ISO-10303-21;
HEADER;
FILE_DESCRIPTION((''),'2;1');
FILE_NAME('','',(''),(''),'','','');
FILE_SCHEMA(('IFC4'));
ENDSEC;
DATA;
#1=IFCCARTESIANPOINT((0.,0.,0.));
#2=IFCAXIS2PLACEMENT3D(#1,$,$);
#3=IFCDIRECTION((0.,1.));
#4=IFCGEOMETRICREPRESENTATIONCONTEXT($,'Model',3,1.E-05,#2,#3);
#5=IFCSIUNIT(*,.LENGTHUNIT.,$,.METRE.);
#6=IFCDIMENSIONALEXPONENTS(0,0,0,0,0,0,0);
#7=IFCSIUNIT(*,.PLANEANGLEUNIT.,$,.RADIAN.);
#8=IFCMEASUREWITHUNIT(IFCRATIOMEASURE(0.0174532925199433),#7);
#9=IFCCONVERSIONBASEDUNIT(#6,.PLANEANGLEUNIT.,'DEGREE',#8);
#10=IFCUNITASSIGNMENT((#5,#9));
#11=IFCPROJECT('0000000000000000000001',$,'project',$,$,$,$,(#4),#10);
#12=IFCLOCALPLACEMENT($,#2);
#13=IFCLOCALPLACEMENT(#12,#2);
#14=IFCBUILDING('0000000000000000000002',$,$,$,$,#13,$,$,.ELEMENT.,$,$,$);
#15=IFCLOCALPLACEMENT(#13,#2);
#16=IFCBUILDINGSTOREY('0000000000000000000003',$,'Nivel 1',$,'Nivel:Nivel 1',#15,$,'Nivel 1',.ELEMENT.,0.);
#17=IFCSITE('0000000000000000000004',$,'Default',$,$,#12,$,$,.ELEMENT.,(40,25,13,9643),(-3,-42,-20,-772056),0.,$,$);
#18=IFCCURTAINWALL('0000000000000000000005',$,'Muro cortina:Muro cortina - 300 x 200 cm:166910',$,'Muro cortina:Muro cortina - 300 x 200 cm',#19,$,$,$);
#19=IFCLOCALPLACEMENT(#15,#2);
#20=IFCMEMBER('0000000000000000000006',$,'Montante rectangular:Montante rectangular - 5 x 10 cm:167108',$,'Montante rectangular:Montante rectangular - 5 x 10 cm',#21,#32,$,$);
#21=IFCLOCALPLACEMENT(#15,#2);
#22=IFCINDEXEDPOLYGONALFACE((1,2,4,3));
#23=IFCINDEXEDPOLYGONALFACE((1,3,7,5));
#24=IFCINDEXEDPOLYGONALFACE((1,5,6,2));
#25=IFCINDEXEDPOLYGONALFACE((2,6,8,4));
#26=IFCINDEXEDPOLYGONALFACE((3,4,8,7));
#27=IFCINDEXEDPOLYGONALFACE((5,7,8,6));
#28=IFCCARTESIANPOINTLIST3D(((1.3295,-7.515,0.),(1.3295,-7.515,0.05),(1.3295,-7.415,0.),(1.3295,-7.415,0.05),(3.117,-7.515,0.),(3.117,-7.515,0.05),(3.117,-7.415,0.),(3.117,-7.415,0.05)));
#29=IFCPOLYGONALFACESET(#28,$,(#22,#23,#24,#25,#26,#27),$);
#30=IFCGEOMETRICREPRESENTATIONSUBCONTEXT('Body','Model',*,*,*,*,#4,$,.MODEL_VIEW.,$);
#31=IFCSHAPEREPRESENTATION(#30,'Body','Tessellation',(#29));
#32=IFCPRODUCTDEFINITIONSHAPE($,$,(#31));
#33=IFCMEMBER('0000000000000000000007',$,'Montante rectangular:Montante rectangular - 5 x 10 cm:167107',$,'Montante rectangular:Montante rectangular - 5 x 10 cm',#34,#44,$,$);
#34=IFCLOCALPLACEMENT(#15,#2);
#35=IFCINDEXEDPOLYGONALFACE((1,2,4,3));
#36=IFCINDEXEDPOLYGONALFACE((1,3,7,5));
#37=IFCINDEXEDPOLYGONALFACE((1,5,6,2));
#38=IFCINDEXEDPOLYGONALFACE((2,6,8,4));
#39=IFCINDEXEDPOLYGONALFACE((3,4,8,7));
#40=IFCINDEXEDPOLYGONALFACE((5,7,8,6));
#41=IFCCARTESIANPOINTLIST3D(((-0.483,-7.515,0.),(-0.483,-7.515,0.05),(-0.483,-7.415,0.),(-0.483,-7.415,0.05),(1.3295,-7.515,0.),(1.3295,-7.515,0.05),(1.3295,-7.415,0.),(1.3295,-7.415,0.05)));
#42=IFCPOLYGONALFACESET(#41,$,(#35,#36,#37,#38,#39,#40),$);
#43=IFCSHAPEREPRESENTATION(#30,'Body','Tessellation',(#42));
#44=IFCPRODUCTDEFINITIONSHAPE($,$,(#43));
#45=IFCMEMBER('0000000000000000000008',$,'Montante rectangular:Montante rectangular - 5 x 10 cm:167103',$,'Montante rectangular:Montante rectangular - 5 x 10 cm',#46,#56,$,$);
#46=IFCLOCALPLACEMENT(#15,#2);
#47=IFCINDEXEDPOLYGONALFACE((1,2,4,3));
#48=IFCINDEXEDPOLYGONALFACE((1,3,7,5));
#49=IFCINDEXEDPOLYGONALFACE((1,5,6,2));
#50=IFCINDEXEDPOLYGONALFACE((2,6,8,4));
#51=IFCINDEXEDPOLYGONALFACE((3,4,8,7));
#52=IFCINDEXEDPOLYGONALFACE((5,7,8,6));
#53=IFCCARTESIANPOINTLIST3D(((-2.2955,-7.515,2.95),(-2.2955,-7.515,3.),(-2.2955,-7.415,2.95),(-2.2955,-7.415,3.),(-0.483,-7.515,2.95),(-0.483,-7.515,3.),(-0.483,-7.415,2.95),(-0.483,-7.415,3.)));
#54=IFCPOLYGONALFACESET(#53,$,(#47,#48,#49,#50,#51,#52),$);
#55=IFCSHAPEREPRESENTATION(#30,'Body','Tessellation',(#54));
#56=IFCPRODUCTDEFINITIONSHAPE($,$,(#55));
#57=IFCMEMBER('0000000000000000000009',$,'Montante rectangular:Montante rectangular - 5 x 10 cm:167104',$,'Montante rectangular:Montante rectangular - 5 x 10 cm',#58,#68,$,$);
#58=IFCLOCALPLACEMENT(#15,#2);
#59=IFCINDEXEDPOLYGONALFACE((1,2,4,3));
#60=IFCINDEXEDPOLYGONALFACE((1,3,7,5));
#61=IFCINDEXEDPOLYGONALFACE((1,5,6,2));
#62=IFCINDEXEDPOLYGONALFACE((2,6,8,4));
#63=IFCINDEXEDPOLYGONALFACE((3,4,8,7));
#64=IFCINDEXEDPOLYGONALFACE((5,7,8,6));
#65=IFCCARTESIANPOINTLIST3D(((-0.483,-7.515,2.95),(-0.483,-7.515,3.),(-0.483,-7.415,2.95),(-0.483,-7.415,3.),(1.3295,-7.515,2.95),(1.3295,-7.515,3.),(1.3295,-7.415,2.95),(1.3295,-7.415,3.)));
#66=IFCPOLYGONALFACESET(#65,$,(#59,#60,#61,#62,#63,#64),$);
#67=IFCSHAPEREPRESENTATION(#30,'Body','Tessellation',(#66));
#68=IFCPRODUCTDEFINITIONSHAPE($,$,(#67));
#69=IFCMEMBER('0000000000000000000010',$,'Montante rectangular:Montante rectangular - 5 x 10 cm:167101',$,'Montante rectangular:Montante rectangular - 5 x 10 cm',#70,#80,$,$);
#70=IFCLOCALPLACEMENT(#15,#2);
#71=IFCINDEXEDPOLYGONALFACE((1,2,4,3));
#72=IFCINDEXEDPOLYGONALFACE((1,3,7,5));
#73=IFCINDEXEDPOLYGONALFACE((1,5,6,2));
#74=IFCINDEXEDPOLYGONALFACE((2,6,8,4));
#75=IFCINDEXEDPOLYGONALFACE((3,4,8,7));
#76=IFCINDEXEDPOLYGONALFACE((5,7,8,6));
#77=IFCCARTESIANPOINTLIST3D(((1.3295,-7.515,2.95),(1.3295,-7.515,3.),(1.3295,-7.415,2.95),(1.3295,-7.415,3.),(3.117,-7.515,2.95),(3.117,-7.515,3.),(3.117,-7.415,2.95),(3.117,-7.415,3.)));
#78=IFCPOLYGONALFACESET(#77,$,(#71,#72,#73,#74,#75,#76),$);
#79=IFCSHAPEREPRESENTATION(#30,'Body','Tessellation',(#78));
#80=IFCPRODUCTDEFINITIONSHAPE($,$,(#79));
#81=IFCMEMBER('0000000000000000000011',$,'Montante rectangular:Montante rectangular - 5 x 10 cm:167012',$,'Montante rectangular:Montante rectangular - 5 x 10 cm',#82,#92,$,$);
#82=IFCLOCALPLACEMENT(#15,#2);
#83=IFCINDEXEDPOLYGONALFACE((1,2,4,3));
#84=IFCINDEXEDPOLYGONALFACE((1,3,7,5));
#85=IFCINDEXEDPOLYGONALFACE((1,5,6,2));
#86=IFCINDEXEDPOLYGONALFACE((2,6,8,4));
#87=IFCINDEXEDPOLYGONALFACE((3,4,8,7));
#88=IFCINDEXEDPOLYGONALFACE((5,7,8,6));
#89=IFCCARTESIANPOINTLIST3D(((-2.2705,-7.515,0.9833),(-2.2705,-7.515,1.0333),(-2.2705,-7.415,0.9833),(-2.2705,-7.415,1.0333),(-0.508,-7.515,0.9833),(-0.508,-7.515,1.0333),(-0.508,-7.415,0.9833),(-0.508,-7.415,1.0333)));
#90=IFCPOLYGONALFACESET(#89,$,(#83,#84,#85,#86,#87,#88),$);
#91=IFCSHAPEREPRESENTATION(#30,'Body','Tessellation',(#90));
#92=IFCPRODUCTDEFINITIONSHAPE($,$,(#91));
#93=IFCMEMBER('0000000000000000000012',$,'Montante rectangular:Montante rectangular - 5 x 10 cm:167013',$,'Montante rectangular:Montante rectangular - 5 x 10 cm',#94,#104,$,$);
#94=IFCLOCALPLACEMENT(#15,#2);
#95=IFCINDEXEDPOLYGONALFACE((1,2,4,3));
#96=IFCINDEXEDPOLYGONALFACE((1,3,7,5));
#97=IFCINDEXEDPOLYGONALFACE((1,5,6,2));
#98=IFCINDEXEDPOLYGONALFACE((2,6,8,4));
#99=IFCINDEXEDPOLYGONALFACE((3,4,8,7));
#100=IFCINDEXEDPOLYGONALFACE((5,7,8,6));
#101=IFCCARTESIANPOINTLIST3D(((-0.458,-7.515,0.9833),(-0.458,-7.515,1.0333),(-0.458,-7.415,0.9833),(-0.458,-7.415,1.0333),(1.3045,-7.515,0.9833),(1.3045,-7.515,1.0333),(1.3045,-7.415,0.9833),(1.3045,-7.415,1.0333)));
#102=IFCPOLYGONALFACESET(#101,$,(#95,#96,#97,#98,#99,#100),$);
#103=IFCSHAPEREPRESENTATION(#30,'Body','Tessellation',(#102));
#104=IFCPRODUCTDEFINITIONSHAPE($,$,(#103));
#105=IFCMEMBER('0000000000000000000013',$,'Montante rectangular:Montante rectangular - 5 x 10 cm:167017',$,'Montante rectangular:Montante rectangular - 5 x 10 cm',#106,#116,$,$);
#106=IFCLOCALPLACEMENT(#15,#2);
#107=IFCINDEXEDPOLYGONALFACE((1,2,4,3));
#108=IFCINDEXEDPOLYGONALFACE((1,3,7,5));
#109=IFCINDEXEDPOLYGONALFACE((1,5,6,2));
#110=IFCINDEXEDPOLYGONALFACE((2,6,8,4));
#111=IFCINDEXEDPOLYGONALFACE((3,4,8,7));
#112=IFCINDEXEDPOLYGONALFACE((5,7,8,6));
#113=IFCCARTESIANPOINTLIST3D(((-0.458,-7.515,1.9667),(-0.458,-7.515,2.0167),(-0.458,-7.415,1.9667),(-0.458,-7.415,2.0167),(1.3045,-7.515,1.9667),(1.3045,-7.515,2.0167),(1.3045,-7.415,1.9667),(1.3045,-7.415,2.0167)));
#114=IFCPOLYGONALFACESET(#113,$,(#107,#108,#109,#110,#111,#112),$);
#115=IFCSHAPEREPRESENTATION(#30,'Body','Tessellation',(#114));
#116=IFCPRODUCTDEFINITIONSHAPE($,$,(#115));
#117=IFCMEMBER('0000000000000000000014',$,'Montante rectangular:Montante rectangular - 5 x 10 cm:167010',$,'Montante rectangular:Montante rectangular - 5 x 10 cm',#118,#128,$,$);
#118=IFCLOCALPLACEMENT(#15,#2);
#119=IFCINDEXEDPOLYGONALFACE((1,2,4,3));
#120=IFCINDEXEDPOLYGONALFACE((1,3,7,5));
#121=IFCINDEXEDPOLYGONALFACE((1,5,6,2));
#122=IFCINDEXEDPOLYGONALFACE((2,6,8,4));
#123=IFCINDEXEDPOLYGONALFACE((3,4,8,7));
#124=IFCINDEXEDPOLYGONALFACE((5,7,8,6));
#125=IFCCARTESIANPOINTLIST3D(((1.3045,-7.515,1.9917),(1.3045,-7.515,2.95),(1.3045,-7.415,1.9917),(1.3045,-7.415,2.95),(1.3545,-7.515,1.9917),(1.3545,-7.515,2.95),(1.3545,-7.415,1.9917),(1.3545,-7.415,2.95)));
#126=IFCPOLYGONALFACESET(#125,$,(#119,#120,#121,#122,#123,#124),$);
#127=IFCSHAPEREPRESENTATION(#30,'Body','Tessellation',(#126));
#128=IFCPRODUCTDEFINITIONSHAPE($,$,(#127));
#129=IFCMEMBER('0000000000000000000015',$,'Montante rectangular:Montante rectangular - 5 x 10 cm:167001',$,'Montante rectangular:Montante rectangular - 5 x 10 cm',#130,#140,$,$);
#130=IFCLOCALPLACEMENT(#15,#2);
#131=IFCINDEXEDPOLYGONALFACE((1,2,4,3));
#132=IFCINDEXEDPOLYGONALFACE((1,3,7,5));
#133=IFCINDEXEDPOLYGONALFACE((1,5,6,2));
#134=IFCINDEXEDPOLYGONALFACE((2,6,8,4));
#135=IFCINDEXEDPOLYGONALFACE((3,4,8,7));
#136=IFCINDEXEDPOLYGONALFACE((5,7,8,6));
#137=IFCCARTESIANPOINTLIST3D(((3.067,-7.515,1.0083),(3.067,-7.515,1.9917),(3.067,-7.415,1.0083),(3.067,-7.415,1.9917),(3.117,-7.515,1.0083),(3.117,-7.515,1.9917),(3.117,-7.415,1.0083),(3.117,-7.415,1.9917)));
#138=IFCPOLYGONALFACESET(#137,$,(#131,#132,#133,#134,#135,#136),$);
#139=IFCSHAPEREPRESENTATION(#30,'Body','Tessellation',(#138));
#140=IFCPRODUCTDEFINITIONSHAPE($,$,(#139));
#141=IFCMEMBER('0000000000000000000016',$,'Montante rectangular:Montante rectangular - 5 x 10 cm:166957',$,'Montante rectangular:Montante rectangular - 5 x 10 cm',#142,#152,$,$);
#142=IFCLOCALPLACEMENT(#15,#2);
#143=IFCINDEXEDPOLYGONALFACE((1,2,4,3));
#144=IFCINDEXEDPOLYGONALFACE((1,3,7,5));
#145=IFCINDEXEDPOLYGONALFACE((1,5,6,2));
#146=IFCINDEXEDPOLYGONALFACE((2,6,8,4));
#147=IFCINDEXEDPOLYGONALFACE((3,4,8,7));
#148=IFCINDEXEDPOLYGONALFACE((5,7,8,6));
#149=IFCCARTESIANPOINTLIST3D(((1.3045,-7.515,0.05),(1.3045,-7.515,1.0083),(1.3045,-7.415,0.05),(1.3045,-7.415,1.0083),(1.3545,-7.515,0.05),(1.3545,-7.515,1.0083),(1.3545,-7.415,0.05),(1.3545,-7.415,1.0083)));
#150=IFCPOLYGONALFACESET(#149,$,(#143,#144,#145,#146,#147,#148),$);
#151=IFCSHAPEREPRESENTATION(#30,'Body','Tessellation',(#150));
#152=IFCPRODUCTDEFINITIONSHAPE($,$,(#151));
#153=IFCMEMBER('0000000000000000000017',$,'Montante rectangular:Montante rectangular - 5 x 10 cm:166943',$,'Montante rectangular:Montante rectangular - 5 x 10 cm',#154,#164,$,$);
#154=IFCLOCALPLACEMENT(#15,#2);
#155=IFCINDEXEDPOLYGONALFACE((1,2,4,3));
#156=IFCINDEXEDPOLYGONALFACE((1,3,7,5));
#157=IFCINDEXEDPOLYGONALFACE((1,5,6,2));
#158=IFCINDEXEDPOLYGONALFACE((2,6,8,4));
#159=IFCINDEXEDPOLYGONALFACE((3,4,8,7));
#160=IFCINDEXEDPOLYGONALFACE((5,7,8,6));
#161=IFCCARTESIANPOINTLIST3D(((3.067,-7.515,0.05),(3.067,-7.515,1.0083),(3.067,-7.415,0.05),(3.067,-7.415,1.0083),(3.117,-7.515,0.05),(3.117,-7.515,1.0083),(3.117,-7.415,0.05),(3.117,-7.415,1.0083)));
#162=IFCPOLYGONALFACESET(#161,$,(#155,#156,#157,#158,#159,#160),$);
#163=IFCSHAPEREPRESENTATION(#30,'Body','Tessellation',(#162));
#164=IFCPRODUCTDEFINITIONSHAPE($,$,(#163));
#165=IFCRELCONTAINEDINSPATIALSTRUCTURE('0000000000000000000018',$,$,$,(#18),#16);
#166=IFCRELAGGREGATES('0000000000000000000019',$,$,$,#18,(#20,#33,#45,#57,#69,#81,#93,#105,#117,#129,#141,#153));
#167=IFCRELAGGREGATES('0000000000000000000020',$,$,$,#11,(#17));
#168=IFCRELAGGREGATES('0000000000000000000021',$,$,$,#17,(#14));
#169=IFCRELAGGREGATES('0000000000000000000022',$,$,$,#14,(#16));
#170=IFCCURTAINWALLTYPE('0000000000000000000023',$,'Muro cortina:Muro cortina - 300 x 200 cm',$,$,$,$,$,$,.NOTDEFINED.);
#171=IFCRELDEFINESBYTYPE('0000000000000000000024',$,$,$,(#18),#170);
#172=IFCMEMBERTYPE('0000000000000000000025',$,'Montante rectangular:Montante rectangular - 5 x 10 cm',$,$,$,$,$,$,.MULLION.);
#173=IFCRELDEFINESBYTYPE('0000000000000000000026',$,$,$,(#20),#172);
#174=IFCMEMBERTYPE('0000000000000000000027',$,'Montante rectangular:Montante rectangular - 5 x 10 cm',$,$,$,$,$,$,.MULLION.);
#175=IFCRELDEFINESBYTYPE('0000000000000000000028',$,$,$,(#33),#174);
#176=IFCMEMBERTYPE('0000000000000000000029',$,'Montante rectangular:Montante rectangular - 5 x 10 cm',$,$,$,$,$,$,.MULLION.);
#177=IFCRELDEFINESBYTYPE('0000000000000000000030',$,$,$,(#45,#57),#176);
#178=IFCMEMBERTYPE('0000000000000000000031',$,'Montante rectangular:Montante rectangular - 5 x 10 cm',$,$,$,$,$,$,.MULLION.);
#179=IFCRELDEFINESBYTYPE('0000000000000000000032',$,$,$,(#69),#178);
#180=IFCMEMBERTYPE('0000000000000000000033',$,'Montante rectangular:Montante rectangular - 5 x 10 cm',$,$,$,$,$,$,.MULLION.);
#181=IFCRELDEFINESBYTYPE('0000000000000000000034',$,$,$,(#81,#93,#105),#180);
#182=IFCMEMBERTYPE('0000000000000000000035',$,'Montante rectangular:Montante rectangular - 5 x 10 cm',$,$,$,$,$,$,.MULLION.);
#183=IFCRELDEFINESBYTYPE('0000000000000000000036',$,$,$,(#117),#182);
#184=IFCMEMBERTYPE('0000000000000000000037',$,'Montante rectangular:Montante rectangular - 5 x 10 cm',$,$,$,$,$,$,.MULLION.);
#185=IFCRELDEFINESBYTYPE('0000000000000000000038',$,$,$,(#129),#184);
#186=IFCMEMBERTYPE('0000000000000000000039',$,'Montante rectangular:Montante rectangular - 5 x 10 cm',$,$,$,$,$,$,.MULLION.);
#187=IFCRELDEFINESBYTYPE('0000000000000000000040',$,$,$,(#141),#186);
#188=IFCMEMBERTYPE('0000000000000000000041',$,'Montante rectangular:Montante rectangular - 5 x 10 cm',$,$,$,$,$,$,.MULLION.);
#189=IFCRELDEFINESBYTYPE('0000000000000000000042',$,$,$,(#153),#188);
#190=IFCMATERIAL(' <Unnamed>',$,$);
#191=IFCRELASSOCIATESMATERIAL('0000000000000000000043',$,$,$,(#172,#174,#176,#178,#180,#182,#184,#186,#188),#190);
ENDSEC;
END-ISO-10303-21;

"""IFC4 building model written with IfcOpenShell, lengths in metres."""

from ifc_helpers import new_model, entity, si_unit, converted_unit, direction, frame, origin, origin_2d_with_axis, place, context, subcontext, project, spatial, rectangle, extrude, source, transform, mapped, material, type_object, type_shapes, element, aggregate, save


model = new_model("IFC4")

# Units and contexts
model_context = context("Model", 3, precision=1e-05, world=origin(), true_north=direction((0.0, 1.0)))
body_context = subcontext(model_context, "Body", "Model", "MODEL_VIEW")
ifc_project = project(units=[si_unit("LENGTHUNIT", "METRE"), converted_unit("PLANEANGLEUNIT", "DEGREE", entity("IfcRatioMeasure", 0.0174532925199433), si_unit("PLANEANGLEUNIT", "RADIAN"), dimensions=[0, 0, 0, 0, 0, 0, 0])], contexts=[model_context])

# Site, building, storey
site_placement = place(None, origin())
site = spatial("IfcSite", under=ifc_project, at=site_placement, Name="Default", CompositionType="ELEMENT", RefLatitude=(40, 25, 13, 9643), RefLongitude=(-3, -42, -20, -772056), RefElevation=0.0)
building_placement = place(site_placement, origin())
building = spatial("IfcBuilding", under=site, at=building_placement, CompositionType="ELEMENT")
storey_placement = place(building_placement, origin())
storey = spatial("IfcBuildingStorey", under=building, at=storey_placement, Name="Nivel 1", ObjectType="Nivel:Nivel 1", LongName="Nivel 1", CompositionType="ELEMENT", Elevation=0.0)

# Curtain wall, members
curtain_wall_type = type_object("IfcCurtainWallType", Name="Muro cortina:Muro cortina - 300 x 200 cm", PredefinedType="NOTDEFINED")
curtain_wall_placement = place(storey_placement, origin())
curtain_wall = element("IfcCurtainWall", 1, at=curtain_wall_placement, inside=storey, type_object=curtain_wall_type, Name="Muro cortina:Muro cortina - 300 x 200 cm:166910", ObjectType="Muro cortina:Muro cortina - 300 x 200 cm")
ifc_material_1 = material(Name=" <Unnamed>")
member_type_1 = type_object("IfcMemberType", Name="Montante rectangular:Montante rectangular - 5 x 10 cm", PredefinedType="MULLION", material=ifc_material_1)
shared_shape_1 = source(origin(), body_context, "Body", "SweptSolid", [
    extrude(rectangle(XDim=0.1, YDim=0.05, at=origin_2d_with_axis()), frame((-0.025, 0.0, -1.7875), z_axis=(0.0, 0.0, 1.0), x_axis=(0.0, -1.0, 0.0)), (0.0, 0.0, 1.0), 1.7875),
])
type_shapes(member_type_1, [shared_shape_1])
member_1_placement = place(storey_placement, frame((1.3295, -7.465, 0.0), z_axis=(-1.0, 0.0, 0.0), x_axis=(0.0, 0.0, -1.0)))
member_1 = element("IfcMember", 2, at=member_1_placement, type_object=member_type_1, Name="Montante rectangular:Montante rectangular - 5 x 10 cm:167108", ObjectType="Montante rectangular:Montante rectangular - 5 x 10 cm", context=body_context, shape_type="MappedRepresentation", body=[
    mapped(shared_shape_1, transform((0.0, 0.0, 0.0), scale=1.0)),
])
member_type_2 = type_object("IfcMemberType", Name="Montante rectangular:Montante rectangular - 5 x 10 cm", PredefinedType="MULLION", material=ifc_material_1)
shared_shape_2 = source(origin(), body_context, "Body", "SweptSolid", [
    extrude(rectangle(XDim=0.1, YDim=0.05, at=origin_2d_with_axis()), frame((-0.025, 0.0, -1.8125), z_axis=(0.0, 0.0, 1.0), x_axis=(0.0, -1.0, 0.0)), (0.0, 0.0, 1.0), 1.8125),
])
type_shapes(member_type_2, [shared_shape_2])
member_2_placement = place(storey_placement, frame((-0.483, -7.465, 0.0), z_axis=(-1.0, 0.0, 0.0), x_axis=(0.0, 0.0, -1.0)))
member_2 = element("IfcMember", 3, at=member_2_placement, type_object=member_type_2, Name="Montante rectangular:Montante rectangular - 5 x 10 cm:167107", ObjectType="Montante rectangular:Montante rectangular - 5 x 10 cm", context=body_context, shape_type="MappedRepresentation", body=[
    mapped(shared_shape_2, transform((0.0, 0.0, 0.0), scale=1.0)),
])
member_type_3 = type_object("IfcMemberType", Name="Montante rectangular:Montante rectangular - 5 x 10 cm", PredefinedType="MULLION", material=ifc_material_1)
shared_shape_3 = source(origin(), body_context, "Body", "SweptSolid", [
    extrude(rectangle(XDim=0.1, YDim=0.05, at=origin_2d_with_axis()), frame((-0.025, 0.0, -1.8125), z_axis=(0.0, 0.0, 1.0), x_axis=(0.0, -1.0, 0.0)), (0.0, 0.0, 1.0), 1.8125),
])
type_shapes(member_type_3, [shared_shape_3])
member_3_placement = place(storey_placement, frame((-0.483, -7.465, 3.0), z_axis=(1.0, 0.0, 0.0), x_axis=(0.0, 0.0, 1.0)))
member_3 = element("IfcMember", 4, at=member_3_placement, type_object=member_type_3, Name="Montante rectangular:Montante rectangular - 5 x 10 cm:167103", ObjectType="Montante rectangular:Montante rectangular - 5 x 10 cm", context=body_context, shape_type="MappedRepresentation", body=[
    mapped(shared_shape_3, transform((0.0, 0.0, 0.0), scale=1.0)),
])
member_4_placement = place(storey_placement, frame((1.3295, -7.465, 3.0), z_axis=(1.0, 0.0, 0.0), x_axis=(0.0, 0.0, 1.0)))
member_4 = element("IfcMember", 5, at=member_4_placement, type_object=member_type_3, Name="Montante rectangular:Montante rectangular - 5 x 10 cm:167104", ObjectType="Montante rectangular:Montante rectangular - 5 x 10 cm", context=body_context, shape_type="MappedRepresentation", body=[
    mapped(shared_shape_3, transform((0.0, 0.0, 0.0), scale=1.0)),
])
member_type_4 = type_object("IfcMemberType", Name="Montante rectangular:Montante rectangular - 5 x 10 cm", PredefinedType="MULLION", material=ifc_material_1)
shared_shape_4 = source(origin(), body_context, "Body", "SweptSolid", [
    extrude(rectangle(XDim=0.1, YDim=0.05, at=origin_2d_with_axis()), frame((-0.025, 0.0, -1.7875), z_axis=(0.0, 0.0, 1.0), x_axis=(0.0, -1.0, 0.0)), (0.0, 0.0, 1.0), 1.7875),
])
type_shapes(member_type_4, [shared_shape_4])
member_5_placement = place(storey_placement, frame((3.117, -7.465, 3.0), z_axis=(1.0, 0.0, 0.0), x_axis=(0.0, 0.0, 1.0)))
member_5 = element("IfcMember", 6, at=member_5_placement, type_object=member_type_4, Name="Montante rectangular:Montante rectangular - 5 x 10 cm:167101", ObjectType="Montante rectangular:Montante rectangular - 5 x 10 cm", context=body_context, shape_type="MappedRepresentation", body=[
    mapped(shared_shape_4, transform((0.0, 0.0, 0.0), scale=1.0)),
])
member_type_5 = type_object("IfcMemberType", Name="Montante rectangular:Montante rectangular - 5 x 10 cm", PredefinedType="MULLION", material=ifc_material_1)
shared_shape_5 = source(origin(), body_context, "Body", "SweptSolid", [
    extrude(rectangle(XDim=0.1, YDim=0.05, at=origin_2d_with_axis()), frame((0.0, 0.0, -1.7625), z_axis=(0.0, 0.0, 1.0), x_axis=(0.0, -1.0, 0.0)), (0.0, 0.0, 1.0), 1.7625),
])
type_shapes(member_type_5, [shared_shape_5])
member_6_placement = place(storey_placement, frame((-0.508, -7.465, 1.0083), z_axis=(1.0, 0.0, 0.0), x_axis=(0.0, 0.0, 1.0)))
member_6 = element("IfcMember", 7, at=member_6_placement, type_object=member_type_5, Name="Montante rectangular:Montante rectangular - 5 x 10 cm:167012", ObjectType="Montante rectangular:Montante rectangular - 5 x 10 cm", context=body_context, shape_type="MappedRepresentation", body=[
    mapped(shared_shape_5, transform((0.0, 0.0, 0.0), scale=1.0)),
])
member_7_placement = place(storey_placement, frame((1.3045, -7.465, 1.0083), z_axis=(1.0, 0.0, 0.0), x_axis=(0.0, 0.0, 1.0)))
member_7 = element("IfcMember", 8, at=member_7_placement, type_object=member_type_5, Name="Montante rectangular:Montante rectangular - 5 x 10 cm:167013", ObjectType="Montante rectangular:Montante rectangular - 5 x 10 cm", context=body_context, shape_type="MappedRepresentation", body=[
    mapped(shared_shape_5, transform((0.0, 0.0, 0.0), scale=1.0)),
])
member_8_placement = place(storey_placement, frame((1.3045, -7.465, 1.9917), z_axis=(1.0, 0.0, 0.0), x_axis=(0.0, 0.0, 1.0)))
member_8 = element("IfcMember", 9, at=member_8_placement, type_object=member_type_5, Name="Montante rectangular:Montante rectangular - 5 x 10 cm:167017", ObjectType="Montante rectangular:Montante rectangular - 5 x 10 cm", context=body_context, shape_type="MappedRepresentation", body=[
    mapped(shared_shape_5, transform((0.0, 0.0, 0.0), scale=1.0)),
])
member_type_6 = type_object("IfcMemberType", Name="Montante rectangular:Montante rectangular - 5 x 10 cm", PredefinedType="MULLION", material=ifc_material_1)
shared_shape_6 = source(origin(), body_context, "Body", "SweptSolid", [
    extrude(rectangle(XDim=0.1, YDim=0.05, at=origin_2d_with_axis()), frame((0.0, 0.0, -0.9583), z_axis=(0.0, 0.0, 1.0), x_axis=(0.0, -1.0, 0.0)), (0.0, 0.0, 1.0), 0.9583),
])
type_shapes(member_type_6, [shared_shape_6])
member_9_placement = place(storey_placement, frame((1.3295, -7.465, 1.9917), z_axis=(0.0, 0.0, -1.0), x_axis=(1.0, 0.0, 0.0)))
member_9 = element("IfcMember", 10, at=member_9_placement, type_object=member_type_6, Name="Montante rectangular:Montante rectangular - 5 x 10 cm:167010", ObjectType="Montante rectangular:Montante rectangular - 5 x 10 cm", context=body_context, shape_type="MappedRepresentation", body=[
    mapped(shared_shape_6, transform((0.0, 0.0, 0.0), scale=1.0)),
])
member_type_7 = type_object("IfcMemberType", Name="Montante rectangular:Montante rectangular - 5 x 10 cm", PredefinedType="MULLION", material=ifc_material_1)
shared_shape_7 = source(origin(), body_context, "Body", "SweptSolid", [
    extrude(rectangle(XDim=0.1, YDim=0.05, at=origin_2d_with_axis()), frame((-0.025, 0.0, -0.9833), z_axis=(0.0, 0.0, 1.0), x_axis=(0.0, -1.0, 0.0)), (0.0, 0.0, 1.0), 0.9833),
])
type_shapes(member_type_7, [shared_shape_7])
member_10_placement = place(storey_placement, frame((3.117, -7.465, 1.0083), z_axis=(0.0, 0.0, -1.0), x_axis=(1.0, 0.0, 0.0)))
member_10 = element("IfcMember", 11, at=member_10_placement, type_object=member_type_7, Name="Montante rectangular:Montante rectangular - 5 x 10 cm:167001", ObjectType="Montante rectangular:Montante rectangular - 5 x 10 cm", context=body_context, shape_type="MappedRepresentation", body=[
    mapped(shared_shape_7, transform((0.0, 0.0, 0.0), scale=1.0)),
])
member_type_8 = type_object("IfcMemberType", Name="Montante rectangular:Montante rectangular - 5 x 10 cm", PredefinedType="MULLION", material=ifc_material_1)
shared_shape_8 = source(origin(), body_context, "Body", "SweptSolid", [
    extrude(rectangle(XDim=0.1, YDim=0.05, at=origin_2d_with_axis()), frame((0.0, 0.0, -0.9583), z_axis=(0.0, 0.0, 1.0), x_axis=(0.0, -1.0, 0.0)), (0.0, 0.0, 1.0), 0.9583),
])
type_shapes(member_type_8, [shared_shape_8])
member_11_placement = place(storey_placement, frame((1.3295, -7.465, 0.05), z_axis=(0.0, 0.0, -1.0), x_axis=(1.0, 0.0, 0.0)))
member_11 = element("IfcMember", 12, at=member_11_placement, type_object=member_type_8, Name="Montante rectangular:Montante rectangular - 5 x 10 cm:166957", ObjectType="Montante rectangular:Montante rectangular - 5 x 10 cm", context=body_context, shape_type="MappedRepresentation", body=[
    mapped(shared_shape_8, transform((0.0, 0.0, 0.0), scale=1.0)),
])
member_type_9 = type_object("IfcMemberType", Name="Montante rectangular:Montante rectangular - 5 x 10 cm", PredefinedType="MULLION", material=ifc_material_1)
shared_shape_9 = source(origin(), body_context, "Body", "SweptSolid", [
    extrude(rectangle(XDim=0.1, YDim=0.05, at=origin_2d_with_axis()), frame((-0.025, 0.0, -0.9583), z_axis=(0.0, 0.0, 1.0), x_axis=(0.0, -1.0, 0.0)), (0.0, 0.0, 1.0), 0.9583),
])
type_shapes(member_type_9, [shared_shape_9])
member_12_placement = place(storey_placement, frame((3.117, -7.465, 0.05), z_axis=(0.0, 0.0, -1.0), x_axis=(1.0, 0.0, 0.0)))
member_12 = element("IfcMember", 13, at=member_12_placement, type_object=member_type_9, Name="Montante rectangular:Montante rectangular - 5 x 10 cm:166943", ObjectType="Montante rectangular:Montante rectangular - 5 x 10 cm", context=body_context, shape_type="MappedRepresentation", body=[
    mapped(shared_shape_9, transform((0.0, 0.0, 0.0), scale=1.0)),
])
aggregate(curtain_wall, [member_1, member_2, member_3, member_4, member_5, member_6, member_7, member_8, member_9, member_10, member_11, member_12])

save(model, "model.ifc")
